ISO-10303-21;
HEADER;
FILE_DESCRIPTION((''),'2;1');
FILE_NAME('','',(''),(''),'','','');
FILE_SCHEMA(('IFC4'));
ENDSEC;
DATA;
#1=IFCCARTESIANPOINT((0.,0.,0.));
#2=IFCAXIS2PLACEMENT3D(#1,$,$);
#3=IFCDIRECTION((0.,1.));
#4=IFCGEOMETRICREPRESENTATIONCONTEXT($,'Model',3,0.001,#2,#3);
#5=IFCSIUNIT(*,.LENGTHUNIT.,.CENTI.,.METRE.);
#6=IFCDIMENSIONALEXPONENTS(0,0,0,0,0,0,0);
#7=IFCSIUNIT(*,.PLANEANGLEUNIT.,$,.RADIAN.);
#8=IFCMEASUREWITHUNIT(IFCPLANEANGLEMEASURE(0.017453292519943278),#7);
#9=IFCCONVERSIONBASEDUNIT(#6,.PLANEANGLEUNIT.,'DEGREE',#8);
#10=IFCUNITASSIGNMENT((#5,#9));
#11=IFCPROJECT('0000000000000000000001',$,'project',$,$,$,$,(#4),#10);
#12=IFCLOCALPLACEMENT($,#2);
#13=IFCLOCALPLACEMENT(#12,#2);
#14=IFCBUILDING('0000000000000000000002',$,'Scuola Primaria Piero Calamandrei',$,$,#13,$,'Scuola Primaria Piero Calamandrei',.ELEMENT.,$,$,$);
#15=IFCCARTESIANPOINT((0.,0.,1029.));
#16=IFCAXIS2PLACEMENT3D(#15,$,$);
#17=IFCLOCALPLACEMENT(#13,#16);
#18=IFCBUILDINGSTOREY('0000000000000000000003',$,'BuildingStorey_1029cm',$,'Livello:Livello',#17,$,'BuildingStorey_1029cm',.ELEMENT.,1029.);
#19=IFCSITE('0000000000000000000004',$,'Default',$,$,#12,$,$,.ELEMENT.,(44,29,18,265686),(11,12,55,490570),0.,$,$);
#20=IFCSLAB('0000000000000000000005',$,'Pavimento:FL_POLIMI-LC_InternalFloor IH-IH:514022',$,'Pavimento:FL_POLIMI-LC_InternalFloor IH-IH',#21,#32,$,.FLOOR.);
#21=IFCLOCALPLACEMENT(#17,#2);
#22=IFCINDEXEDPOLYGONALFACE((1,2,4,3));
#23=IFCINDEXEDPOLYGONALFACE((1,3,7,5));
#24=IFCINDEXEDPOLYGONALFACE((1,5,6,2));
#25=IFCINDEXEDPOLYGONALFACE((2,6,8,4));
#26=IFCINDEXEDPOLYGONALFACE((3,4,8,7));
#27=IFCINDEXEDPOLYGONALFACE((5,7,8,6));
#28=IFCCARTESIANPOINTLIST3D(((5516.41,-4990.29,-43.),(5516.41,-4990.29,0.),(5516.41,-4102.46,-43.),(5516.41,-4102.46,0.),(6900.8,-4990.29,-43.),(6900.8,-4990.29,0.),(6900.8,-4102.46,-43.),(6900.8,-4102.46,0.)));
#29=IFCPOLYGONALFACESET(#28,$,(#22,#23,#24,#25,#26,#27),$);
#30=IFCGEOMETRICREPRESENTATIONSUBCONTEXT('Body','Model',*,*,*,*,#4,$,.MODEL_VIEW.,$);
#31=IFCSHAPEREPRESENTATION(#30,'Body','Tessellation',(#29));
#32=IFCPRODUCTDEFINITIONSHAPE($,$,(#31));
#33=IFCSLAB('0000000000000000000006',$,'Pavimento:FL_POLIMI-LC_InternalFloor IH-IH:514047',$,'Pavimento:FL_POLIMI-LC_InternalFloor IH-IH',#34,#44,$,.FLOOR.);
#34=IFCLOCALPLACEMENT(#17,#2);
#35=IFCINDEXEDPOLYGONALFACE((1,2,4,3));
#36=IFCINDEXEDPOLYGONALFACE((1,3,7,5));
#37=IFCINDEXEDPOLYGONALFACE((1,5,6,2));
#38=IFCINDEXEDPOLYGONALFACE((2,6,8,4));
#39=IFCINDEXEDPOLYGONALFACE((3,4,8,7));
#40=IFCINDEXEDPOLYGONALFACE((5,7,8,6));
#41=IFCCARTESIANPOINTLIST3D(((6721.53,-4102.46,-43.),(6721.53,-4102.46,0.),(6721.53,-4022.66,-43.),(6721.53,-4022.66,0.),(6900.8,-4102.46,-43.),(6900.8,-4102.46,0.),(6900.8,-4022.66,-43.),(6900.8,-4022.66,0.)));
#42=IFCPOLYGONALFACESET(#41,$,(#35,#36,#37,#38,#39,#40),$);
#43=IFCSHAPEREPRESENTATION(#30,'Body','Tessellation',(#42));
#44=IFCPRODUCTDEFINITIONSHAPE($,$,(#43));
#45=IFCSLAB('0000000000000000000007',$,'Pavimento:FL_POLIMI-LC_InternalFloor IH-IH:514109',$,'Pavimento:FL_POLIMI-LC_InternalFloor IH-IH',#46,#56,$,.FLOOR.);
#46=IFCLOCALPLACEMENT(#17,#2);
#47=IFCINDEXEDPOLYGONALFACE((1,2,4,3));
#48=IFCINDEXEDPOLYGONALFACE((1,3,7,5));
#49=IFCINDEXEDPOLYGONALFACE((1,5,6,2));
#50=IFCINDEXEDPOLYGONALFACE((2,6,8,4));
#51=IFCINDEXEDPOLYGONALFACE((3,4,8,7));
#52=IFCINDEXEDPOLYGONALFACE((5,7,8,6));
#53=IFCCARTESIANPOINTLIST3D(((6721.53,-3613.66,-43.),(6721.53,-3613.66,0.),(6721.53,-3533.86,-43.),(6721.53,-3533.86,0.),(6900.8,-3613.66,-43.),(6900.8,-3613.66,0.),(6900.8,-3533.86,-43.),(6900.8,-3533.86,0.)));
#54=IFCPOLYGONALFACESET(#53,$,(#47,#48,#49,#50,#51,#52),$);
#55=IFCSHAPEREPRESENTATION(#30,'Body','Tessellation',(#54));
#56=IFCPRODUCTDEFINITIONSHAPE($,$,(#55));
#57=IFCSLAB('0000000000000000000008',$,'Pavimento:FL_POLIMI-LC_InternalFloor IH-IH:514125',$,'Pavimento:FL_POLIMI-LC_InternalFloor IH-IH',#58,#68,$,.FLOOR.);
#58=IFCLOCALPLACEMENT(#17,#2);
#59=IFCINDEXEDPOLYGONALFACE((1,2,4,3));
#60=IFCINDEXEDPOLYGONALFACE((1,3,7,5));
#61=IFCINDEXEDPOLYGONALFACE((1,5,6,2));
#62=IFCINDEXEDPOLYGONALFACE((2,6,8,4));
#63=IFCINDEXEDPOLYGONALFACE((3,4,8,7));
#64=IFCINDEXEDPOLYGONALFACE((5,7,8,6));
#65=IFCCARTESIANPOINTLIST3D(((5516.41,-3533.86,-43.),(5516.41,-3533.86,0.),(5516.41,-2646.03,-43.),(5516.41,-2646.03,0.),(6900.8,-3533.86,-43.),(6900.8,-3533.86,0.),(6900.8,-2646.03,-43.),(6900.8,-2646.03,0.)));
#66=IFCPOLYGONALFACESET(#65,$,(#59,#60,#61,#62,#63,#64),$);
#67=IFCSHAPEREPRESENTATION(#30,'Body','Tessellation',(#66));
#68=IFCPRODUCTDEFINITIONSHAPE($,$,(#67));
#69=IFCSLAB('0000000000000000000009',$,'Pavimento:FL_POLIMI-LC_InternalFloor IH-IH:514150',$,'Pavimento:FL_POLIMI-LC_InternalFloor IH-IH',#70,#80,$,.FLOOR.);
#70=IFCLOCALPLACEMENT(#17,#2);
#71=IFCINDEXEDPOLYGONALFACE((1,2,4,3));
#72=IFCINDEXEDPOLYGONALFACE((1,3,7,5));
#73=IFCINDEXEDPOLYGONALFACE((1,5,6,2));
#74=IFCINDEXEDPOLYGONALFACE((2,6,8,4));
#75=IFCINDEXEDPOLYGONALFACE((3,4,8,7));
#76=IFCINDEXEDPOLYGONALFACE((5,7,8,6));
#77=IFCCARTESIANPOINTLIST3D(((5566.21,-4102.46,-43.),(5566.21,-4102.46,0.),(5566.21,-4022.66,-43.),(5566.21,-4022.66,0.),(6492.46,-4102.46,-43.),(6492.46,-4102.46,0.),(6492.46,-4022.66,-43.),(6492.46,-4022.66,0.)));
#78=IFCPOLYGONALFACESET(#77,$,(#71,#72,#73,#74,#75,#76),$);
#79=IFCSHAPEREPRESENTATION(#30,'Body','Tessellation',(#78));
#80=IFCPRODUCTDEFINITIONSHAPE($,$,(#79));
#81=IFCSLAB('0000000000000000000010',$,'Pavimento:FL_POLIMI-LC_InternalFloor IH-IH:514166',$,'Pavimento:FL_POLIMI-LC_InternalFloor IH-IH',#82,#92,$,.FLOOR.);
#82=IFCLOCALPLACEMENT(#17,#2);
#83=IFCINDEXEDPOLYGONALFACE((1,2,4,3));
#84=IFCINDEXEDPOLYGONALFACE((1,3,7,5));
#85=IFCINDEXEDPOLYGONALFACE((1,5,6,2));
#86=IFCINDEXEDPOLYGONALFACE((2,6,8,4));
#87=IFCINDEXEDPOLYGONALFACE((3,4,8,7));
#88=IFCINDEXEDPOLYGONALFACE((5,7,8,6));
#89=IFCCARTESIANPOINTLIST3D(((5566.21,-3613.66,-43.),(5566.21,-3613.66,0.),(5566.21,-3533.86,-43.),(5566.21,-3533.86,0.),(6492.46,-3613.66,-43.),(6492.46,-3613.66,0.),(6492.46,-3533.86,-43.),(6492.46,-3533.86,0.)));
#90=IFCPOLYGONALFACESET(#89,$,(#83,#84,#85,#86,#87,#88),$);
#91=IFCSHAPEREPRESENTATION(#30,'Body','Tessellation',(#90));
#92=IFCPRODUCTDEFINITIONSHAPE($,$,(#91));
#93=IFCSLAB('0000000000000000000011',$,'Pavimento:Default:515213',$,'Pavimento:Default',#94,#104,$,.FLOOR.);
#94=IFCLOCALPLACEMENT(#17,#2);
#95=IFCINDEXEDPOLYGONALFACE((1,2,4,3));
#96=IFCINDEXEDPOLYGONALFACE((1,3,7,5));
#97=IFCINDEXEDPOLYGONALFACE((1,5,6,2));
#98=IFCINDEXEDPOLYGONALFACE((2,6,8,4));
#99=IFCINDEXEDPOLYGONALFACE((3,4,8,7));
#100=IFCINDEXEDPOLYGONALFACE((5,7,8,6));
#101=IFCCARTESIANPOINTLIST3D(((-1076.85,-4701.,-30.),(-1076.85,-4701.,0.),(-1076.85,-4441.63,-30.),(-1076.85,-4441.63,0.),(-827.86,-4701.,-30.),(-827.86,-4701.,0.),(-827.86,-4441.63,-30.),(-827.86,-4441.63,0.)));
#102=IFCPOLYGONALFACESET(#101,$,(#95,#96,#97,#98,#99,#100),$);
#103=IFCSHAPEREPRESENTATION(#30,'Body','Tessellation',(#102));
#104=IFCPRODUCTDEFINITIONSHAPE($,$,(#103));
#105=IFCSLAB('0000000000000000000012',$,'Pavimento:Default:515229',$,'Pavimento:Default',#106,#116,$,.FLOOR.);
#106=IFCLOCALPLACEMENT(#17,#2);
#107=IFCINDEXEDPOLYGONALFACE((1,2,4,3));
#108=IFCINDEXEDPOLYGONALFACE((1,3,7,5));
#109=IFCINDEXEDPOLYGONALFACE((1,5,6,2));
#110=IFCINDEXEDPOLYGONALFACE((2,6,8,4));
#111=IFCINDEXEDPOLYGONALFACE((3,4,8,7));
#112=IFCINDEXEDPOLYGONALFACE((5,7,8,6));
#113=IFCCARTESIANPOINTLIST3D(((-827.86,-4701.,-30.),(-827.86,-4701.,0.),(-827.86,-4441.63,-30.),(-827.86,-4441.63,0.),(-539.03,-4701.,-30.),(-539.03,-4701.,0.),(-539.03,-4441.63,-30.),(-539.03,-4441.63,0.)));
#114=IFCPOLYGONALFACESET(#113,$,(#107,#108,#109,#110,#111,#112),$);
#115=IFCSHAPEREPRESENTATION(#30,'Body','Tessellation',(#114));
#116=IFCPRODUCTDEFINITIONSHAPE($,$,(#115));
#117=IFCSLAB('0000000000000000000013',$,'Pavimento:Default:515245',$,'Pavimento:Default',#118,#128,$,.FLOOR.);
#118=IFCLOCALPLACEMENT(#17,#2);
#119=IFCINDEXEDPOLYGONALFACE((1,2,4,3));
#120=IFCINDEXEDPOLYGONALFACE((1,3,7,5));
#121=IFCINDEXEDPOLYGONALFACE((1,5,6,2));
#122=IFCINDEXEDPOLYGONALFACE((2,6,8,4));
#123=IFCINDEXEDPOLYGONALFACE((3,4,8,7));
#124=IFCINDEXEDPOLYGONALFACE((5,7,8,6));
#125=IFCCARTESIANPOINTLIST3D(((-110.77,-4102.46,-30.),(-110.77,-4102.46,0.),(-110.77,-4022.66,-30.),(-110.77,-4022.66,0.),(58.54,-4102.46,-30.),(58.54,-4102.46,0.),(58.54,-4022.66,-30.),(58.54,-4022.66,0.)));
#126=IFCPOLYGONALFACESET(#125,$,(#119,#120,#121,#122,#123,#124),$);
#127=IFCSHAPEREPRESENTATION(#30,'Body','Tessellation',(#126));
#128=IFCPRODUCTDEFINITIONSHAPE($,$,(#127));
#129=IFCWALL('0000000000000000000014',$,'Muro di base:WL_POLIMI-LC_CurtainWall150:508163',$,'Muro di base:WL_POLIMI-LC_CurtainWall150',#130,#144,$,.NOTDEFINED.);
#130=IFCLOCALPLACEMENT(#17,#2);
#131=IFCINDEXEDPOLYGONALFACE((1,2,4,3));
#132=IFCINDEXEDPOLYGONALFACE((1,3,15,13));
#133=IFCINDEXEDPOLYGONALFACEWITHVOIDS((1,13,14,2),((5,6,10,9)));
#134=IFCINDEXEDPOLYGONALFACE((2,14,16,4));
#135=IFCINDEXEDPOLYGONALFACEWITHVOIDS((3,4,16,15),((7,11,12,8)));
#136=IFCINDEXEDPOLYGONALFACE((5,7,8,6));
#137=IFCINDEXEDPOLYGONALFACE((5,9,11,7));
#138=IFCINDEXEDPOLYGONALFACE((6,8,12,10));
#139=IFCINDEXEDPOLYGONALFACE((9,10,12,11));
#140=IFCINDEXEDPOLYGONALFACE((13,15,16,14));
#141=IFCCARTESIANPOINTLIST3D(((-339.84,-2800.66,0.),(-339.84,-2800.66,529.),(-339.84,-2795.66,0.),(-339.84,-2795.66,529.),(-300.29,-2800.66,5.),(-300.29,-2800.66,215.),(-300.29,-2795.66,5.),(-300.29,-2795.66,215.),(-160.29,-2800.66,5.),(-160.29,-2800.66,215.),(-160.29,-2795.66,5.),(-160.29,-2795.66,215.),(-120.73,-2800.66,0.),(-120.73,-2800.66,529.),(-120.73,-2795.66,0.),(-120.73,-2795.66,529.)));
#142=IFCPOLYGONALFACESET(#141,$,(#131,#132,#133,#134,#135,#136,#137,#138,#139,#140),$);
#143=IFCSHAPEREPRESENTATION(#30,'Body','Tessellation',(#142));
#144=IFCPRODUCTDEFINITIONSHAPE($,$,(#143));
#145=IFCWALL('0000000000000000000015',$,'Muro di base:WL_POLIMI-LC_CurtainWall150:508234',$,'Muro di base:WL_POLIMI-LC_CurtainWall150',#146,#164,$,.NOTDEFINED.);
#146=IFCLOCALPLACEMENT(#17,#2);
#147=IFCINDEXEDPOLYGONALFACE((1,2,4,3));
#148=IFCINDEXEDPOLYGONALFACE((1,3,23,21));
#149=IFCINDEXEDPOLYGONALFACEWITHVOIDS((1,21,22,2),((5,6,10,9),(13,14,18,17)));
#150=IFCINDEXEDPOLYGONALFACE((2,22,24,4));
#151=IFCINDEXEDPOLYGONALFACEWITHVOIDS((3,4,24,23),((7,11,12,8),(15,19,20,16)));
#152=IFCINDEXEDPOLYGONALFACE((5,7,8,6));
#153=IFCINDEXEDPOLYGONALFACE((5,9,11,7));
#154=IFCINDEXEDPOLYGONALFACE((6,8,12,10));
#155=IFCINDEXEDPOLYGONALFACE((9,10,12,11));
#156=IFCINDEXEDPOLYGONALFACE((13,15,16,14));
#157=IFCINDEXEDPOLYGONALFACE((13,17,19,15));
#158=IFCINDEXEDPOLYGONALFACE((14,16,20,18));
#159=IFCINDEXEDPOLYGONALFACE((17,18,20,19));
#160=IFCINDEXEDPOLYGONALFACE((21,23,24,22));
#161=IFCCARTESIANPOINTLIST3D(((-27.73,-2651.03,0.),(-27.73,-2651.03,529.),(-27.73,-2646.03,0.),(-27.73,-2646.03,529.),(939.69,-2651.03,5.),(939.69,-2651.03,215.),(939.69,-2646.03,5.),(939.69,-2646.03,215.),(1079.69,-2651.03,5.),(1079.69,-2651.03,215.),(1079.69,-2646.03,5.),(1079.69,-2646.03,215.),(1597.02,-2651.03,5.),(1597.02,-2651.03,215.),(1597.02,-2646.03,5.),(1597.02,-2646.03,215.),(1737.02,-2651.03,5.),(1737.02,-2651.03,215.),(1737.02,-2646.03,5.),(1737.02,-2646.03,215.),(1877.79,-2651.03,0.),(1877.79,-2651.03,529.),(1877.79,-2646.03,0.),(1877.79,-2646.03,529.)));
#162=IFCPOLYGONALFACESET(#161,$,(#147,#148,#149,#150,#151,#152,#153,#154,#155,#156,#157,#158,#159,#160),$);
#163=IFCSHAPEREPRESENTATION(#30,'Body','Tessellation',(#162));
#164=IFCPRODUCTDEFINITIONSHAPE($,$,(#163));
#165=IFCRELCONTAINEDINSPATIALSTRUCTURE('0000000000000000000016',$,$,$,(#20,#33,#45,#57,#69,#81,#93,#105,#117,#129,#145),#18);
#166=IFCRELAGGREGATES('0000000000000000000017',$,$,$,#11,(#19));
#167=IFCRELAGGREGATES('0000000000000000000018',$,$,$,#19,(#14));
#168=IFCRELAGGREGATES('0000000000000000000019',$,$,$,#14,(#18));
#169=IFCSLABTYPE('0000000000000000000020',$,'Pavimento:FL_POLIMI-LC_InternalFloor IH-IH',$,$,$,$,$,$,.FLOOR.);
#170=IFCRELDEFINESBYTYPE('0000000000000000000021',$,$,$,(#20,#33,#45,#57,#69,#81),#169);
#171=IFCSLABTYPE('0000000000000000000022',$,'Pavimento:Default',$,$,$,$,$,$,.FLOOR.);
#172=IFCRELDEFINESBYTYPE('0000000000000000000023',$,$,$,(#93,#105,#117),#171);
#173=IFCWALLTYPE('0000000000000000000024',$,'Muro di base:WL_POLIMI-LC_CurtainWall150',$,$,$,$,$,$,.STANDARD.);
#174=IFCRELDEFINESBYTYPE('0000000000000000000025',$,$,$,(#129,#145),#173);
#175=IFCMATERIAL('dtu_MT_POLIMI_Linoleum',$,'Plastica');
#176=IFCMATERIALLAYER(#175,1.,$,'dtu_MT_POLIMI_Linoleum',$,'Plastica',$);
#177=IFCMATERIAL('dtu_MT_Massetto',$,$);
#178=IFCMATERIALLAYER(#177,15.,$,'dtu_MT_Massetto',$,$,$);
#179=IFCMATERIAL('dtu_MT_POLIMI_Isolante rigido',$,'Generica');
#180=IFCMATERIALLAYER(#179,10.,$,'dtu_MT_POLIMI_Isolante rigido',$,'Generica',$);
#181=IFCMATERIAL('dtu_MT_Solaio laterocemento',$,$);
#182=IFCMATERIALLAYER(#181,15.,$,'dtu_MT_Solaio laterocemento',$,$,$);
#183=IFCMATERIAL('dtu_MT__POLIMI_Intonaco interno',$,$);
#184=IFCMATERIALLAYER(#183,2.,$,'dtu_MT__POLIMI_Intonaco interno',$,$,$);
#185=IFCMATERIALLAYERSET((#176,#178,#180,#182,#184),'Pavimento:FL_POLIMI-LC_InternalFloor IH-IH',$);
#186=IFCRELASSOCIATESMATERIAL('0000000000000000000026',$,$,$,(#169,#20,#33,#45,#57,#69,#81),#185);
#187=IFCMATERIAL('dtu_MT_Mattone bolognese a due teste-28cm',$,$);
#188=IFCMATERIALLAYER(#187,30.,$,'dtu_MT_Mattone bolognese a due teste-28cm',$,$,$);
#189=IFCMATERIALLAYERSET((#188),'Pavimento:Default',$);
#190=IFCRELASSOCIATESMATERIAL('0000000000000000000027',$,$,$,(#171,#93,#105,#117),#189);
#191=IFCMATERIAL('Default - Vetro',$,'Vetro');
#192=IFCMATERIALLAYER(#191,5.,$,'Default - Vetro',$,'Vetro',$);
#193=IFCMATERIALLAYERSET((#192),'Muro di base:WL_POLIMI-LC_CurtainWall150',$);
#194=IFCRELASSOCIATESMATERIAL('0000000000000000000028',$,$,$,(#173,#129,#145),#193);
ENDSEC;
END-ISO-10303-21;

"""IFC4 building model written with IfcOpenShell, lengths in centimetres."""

from ifc_helpers import new_model, entity, si_unit, converted_unit, direction, frame, frame_2d, origin, place, context, subcontext, project, spatial, rectangle, extrude, material, layer, layer_set, layer_usage, type_object, element, save


model = new_model("IFC4")

# Units and contexts
model_context = context("Model", 3, precision=0.001, world=origin(), true_north=direction((0.0, 1.0)))
body_context = subcontext(model_context, "Body", "Model", "MODEL_VIEW")
ifc_project = project(units=[si_unit("LENGTHUNIT", "METRE", prefix="CENTI"), converted_unit("PLANEANGLEUNIT", "DEGREE", entity("IfcPlaneAngleMeasure", 0.017453292519943278), si_unit("PLANEANGLEUNIT", "RADIAN"), dimensions=[0, 0, 0, 0, 0, 0, 0])], contexts=[model_context])

# Site, building, storey
site_placement = place(None, origin())
site = spatial("IfcSite", under=ifc_project, at=site_placement, Name="Default", CompositionType="ELEMENT", RefLatitude=(44, 29, 18, 265686), RefLongitude=(11, 12, 55, 490570), RefElevation=0.0)
building_placement = place(site_placement, origin())
building = spatial("IfcBuilding", under=site, at=building_placement, Name="Scuola Primaria Piero Calamandrei", LongName="Scuola Primaria Piero Calamandrei", CompositionType="ELEMENT")
storey_placement = place(building_placement, frame((0.0, 0.0, 1029.0)))
storey = spatial("IfcBuildingStorey", under=building, at=storey_placement, Name="BuildingStorey_1029cm", ObjectType="Livello:Livello", LongName="BuildingStorey_1029cm", CompositionType="ELEMENT", Elevation=1029.0)

# Slabs
ifc_material_1 = material(Name="dtu_MT_POLIMI_Linoleum", Category="Plastica")
ifc_layer_1 = layer(ifc_material_1, 1.0, Name="dtu_MT_POLIMI_Linoleum", Category="Plastica")
ifc_material_2 = material(Name="dtu_MT_Massetto")
ifc_layer_2 = layer(ifc_material_2, 15.0, Name="dtu_MT_Massetto")
ifc_material_3 = material(Name="dtu_MT_POLIMI_Isolante rigido", Category="Generica")
ifc_layer_3 = layer(ifc_material_3, 10.0, Name="dtu_MT_POLIMI_Isolante rigido", Category="Generica")
ifc_material_4 = material(Name="dtu_MT_Solaio laterocemento")
ifc_layer_4 = layer(ifc_material_4, 15.0, Name="dtu_MT_Solaio laterocemento")
ifc_material_5 = material(Name="dtu_MT__POLIMI_Intonaco interno")
ifc_layer_5 = layer(ifc_material_5, 2.0, Name="dtu_MT__POLIMI_Intonaco interno")
ifc_layer_set_1 = layer_set([ifc_layer_1, ifc_layer_2, ifc_layer_3, ifc_layer_4, ifc_layer_5], Name="Pavimento:FL_POLIMI-LC_InternalFloor IH-IH")
slab_type_1 = type_object("IfcSlabType", Name="Pavimento:FL_POLIMI-LC_InternalFloor IH-IH", PredefinedType="FLOOR", material=ifc_layer_set_1)
ifc_layer_usage_1 = layer_usage(ifc_layer_set_1, "AXIS3", "POSITIVE", 0.0)
slab_1_placement = place(storey_placement, origin())
element("IfcSlab", 1, at=slab_1_placement, inside=storey, type_object=slab_type_1, material=ifc_layer_usage_1, Name="Pavimento:FL_POLIMI-LC_InternalFloor IH-IH:514022", ObjectType="Pavimento:FL_POLIMI-LC_InternalFloor IH-IH", PredefinedType="FLOOR", context=body_context, shape_type="SweptSolid", body=[
    extrude(rectangle(XDim=887.82, YDim=1384.39, at=frame_2d((0.0, 0.0), x_axis=(1.0, 0.0))), frame((6208.61, -4546.38, 0.0), z_axis=(0.0, 0.0, -1.0), x_axis=(0.0, 1.0, 0.0)), (0.0, 0.0, 1.0), 43.0),
])
ifc_layer_usage_2 = layer_usage(ifc_layer_set_1, "AXIS3", "POSITIVE", 0.0)
slab_2_placement = place(storey_placement, origin())
element("IfcSlab", 2, at=slab_2_placement, inside=storey, type_object=slab_type_1, material=ifc_layer_usage_2, Name="Pavimento:FL_POLIMI-LC_InternalFloor IH-IH:514047", ObjectType="Pavimento:FL_POLIMI-LC_InternalFloor IH-IH", PredefinedType="FLOOR", context=body_context, shape_type="SweptSolid", body=[
    extrude(rectangle(XDim=79.8, YDim=179.27, at=frame_2d((0.0, 0.0), x_axis=(1.0, 0.0))), frame((6811.16, -4062.56, 0.0), z_axis=(0.0, 0.0, -1.0), x_axis=(0.0, 1.0, 0.0)), (0.0, 0.0, 1.0), 43.0),
])
ifc_layer_usage_3 = layer_usage(ifc_layer_set_1, "AXIS3", "POSITIVE", 0.0)
slab_3_placement = place(storey_placement, origin())
element("IfcSlab", 3, at=slab_3_placement, inside=storey, type_object=slab_type_1, material=ifc_layer_usage_3, Name="Pavimento:FL_POLIMI-LC_InternalFloor IH-IH:514109", ObjectType="Pavimento:FL_POLIMI-LC_InternalFloor IH-IH", PredefinedType="FLOOR", context=body_context, shape_type="SweptSolid", body=[
    extrude(rectangle(XDim=79.8, YDim=179.27, at=frame_2d((0.0, 0.0), x_axis=(1.0, 0.0))), frame((6811.16, -3573.76, 0.0), z_axis=(0.0, 0.0, -1.0), x_axis=(0.0, 1.0, 0.0)), (0.0, 0.0, 1.0), 43.0),
])
ifc_layer_usage_4 = layer_usage(ifc_layer_set_1, "AXIS3", "POSITIVE", 0.0)
slab_4_placement = place(storey_placement, origin())
element("IfcSlab", 4, at=slab_4_placement, inside=storey, type_object=slab_type_1, material=ifc_layer_usage_4, Name="Pavimento:FL_POLIMI-LC_InternalFloor IH-IH:514125", ObjectType="Pavimento:FL_POLIMI-LC_InternalFloor IH-IH", PredefinedType="FLOOR", context=body_context, shape_type="SweptSolid", body=[
    extrude(rectangle(XDim=887.82, YDim=1384.39, at=frame_2d((0.0, 0.0), x_axis=(1.0, 0.0))), frame((6208.61, -3089.94, 0.0), z_axis=(0.0, 0.0, -1.0), x_axis=(0.0, 1.0, 0.0)), (0.0, 0.0, 1.0), 43.0),
])
ifc_layer_usage_5 = layer_usage(ifc_layer_set_1, "AXIS3", "POSITIVE", 0.0)
slab_5_placement = place(storey_placement, origin())
element("IfcSlab", 5, at=slab_5_placement, inside=storey, type_object=slab_type_1, material=ifc_layer_usage_5, Name="Pavimento:FL_POLIMI-LC_InternalFloor IH-IH:514150", ObjectType="Pavimento:FL_POLIMI-LC_InternalFloor IH-IH", PredefinedType="FLOOR", context=body_context, shape_type="SweptSolid", body=[
    extrude(rectangle(XDim=79.8, YDim=926.24, at=frame_2d((0.0, 0.0), x_axis=(1.0, 0.0))), frame((6029.33, -4062.56, 0.0), z_axis=(0.0, 0.0, -1.0), x_axis=(0.0, 1.0, 0.0)), (0.0, 0.0, 1.0), 43.0),
])
ifc_layer_usage_6 = layer_usage(ifc_layer_set_1, "AXIS3", "POSITIVE", 0.0)
slab_6_placement = place(storey_placement, origin())
element("IfcSlab", 6, at=slab_6_placement, inside=storey, type_object=slab_type_1, material=ifc_layer_usage_6, Name="Pavimento:FL_POLIMI-LC_InternalFloor IH-IH:514166", ObjectType="Pavimento:FL_POLIMI-LC_InternalFloor IH-IH", PredefinedType="FLOOR", context=body_context, shape_type="SweptSolid", body=[
    extrude(rectangle(XDim=79.8, YDim=926.24, at=frame_2d((0.0, 0.0), x_axis=(1.0, 0.0))), frame((6029.33, -3573.76, 0.0), z_axis=(0.0, 0.0, -1.0), x_axis=(0.0, 1.0, 0.0)), (0.0, 0.0, 1.0), 43.0),
])
ifc_material_6 = material(Name="dtu_MT_Mattone bolognese a due teste-28cm")
ifc_layer_6 = layer(ifc_material_6, 30.0, Name="dtu_MT_Mattone bolognese a due teste-28cm")
ifc_layer_set_2 = layer_set([ifc_layer_6], Name="Pavimento:Default")
slab_type_2 = type_object("IfcSlabType", Name="Pavimento:Default", PredefinedType="FLOOR", material=ifc_layer_set_2)
ifc_layer_usage_7 = layer_usage(ifc_layer_set_2, "AXIS3", "POSITIVE", 0.0)
slab_7_placement = place(storey_placement, origin())
element("IfcSlab", 7, at=slab_7_placement, inside=storey, type_object=slab_type_2, material=ifc_layer_usage_7, Name="Pavimento:Default:515213", ObjectType="Pavimento:Default", PredefinedType="FLOOR", context=body_context, shape_type="SweptSolid", body=[
    extrude(rectangle(XDim=259.36, YDim=248.99, at=frame_2d((0.0, 0.0), x_axis=(1.0, 0.0))), frame((-952.36, -4571.31, 0.0), z_axis=(0.0, 0.0, -1.0), x_axis=(0.0, 1.0, 0.0)), (0.0, 0.0, 1.0), 30.0),
])
ifc_layer_usage_8 = layer_usage(ifc_layer_set_2, "AXIS3", "POSITIVE", 0.0)
slab_8_placement = place(storey_placement, origin())
element("IfcSlab", 8, at=slab_8_placement, inside=storey, type_object=slab_type_2, material=ifc_layer_usage_8, Name="Pavimento:Default:515229", ObjectType="Pavimento:Default", PredefinedType="FLOOR", context=body_context, shape_type="SweptSolid", body=[
    extrude(rectangle(XDim=259.36, YDim=288.83, at=frame_2d((0.0, 0.0), x_axis=(1.0, 0.0))), frame((-683.45, -4571.31, 0.0), z_axis=(0.0, 0.0, -1.0), x_axis=(0.0, 1.0, 0.0)), (0.0, 0.0, 1.0), 30.0),
])
ifc_layer_usage_9 = layer_usage(ifc_layer_set_2, "AXIS3", "POSITIVE", 0.0)
slab_9_placement = place(storey_placement, origin())
element("IfcSlab", 9, at=slab_9_placement, inside=storey, type_object=slab_type_2, material=ifc_layer_usage_9, Name="Pavimento:Default:515245", ObjectType="Pavimento:Default", PredefinedType="FLOOR", context=body_context, shape_type="SweptSolid", body=[
    extrude(rectangle(XDim=79.8, YDim=169.31, at=frame_2d((0.0, 0.0), x_axis=(1.0, 0.0))), frame((-26.11, -4062.56, 0.0), z_axis=(0.0, 0.0, -1.0), x_axis=(0.0, 1.0, 0.0)), (0.0, 0.0, 1.0), 30.0),
])

# Wall, opening
ifc_material_7 = material(Name="Default - Vetro", Category="Vetro")
ifc_layer_7 = layer(ifc_material_7, 5.0, Name="Default - Vetro", Category="Vetro")
ifc_layer_set_3 = layer_set([ifc_layer_7], Name="Muro di base:WL_POLIMI-LC_CurtainWall150")
ifc_layer_usage_10 = layer_usage(ifc_layer_set_3, "AXIS2", "NEGATIVE", 2.5)
wall_type_1 = type_object("IfcWallType", Name="Muro di base:WL_POLIMI-LC_CurtainWall150", PredefinedType="STANDARD", material=ifc_layer_set_3)
wall_1_placement = place(storey_placement, frame((-339.84, -2798.16, 0.0)))
wall_1 = element("IfcWall", 10, at=wall_1_placement, inside=storey, type_object=wall_type_1, material=ifc_layer_usage_10, Name="Muro di base:WL_POLIMI-LC_CurtainWall150:508163", ObjectType="Muro di base:WL_POLIMI-LC_CurtainWall150", PredefinedType="NOTDEFINED", context=body_context, shape_type="SweptSolid", body=[
    extrude(rectangle(XDim=219.11, YDim=5.0, at=frame_2d((109.56, 0.0), x_axis=(-1.0, 0.0))), origin(), (0.0, 0.0, 1.0), 529.0),
])
opening_1_placement = place(wall_1_placement, frame((179.56, 2.5, 5.0)))
element("IfcOpeningElement", 11, at=opening_1_placement, cuts=wall_1, PredefinedType="OPENING", context=body_context, shape_type="SweptSolid", body=[
    extrude(rectangle(XDim=210.0, YDim=140.0, at=frame_2d((105.0, 70.0), x_axis=(1.0, 0.0))), frame((0.0, 0.0, 0.0), z_axis=(0.0, -1.0, 0.0), x_axis=(0.0, 0.0, 1.0)), (0.0, 0.0, 1.0), 5.0),
])

# Wall, openings
ifc_layer_usage_11 = layer_usage(ifc_layer_set_3, "AXIS2", "NEGATIVE", 2.5)
wall_2_placement = place(storey_placement, frame((-27.73, -2648.53, 0.0)))
wall_2 = element("IfcWall", 12, at=wall_2_placement, inside=storey, type_object=wall_type_1, material=ifc_layer_usage_11, Name="Muro di base:WL_POLIMI-LC_CurtainWall150:508234", ObjectType="Muro di base:WL_POLIMI-LC_CurtainWall150", PredefinedType="NOTDEFINED", context=body_context, shape_type="SweptSolid", body=[
    extrude(rectangle(XDim=1905.52, YDim=5.0, at=frame_2d((952.76, 0.0), x_axis=(-1.0, 0.0))), origin(), (0.0, 0.0, 1.0), 529.0),
])
opening_2_placement = place(wall_2_placement, frame((1624.75, -2.5, 5.0)))
element("IfcOpeningElement", 13, at=opening_2_placement, cuts=wall_2, PredefinedType="OPENING", context=body_context, shape_type="SweptSolid", body=[
    extrude(rectangle(XDim=210.0, YDim=140.0, at=frame_2d((105.0, 70.0), x_axis=(-1.0, 0.0))), frame((0.0, 0.0, 0.0), z_axis=(0.0, 1.0, 0.0), x_axis=(0.0, 0.0, 1.0)), (0.0, 0.0, 1.0), 5.0),
])
opening_3_placement = place(wall_2_placement, frame((967.42, -2.5, 5.0)))
element("IfcOpeningElement", 14, at=opening_3_placement, cuts=wall_2, PredefinedType="OPENING", context=body_context, shape_type="SweptSolid", body=[
    extrude(rectangle(XDim=210.0, YDim=140.0, at=frame_2d((105.0, 70.0), x_axis=(-1.0, 0.0))), frame((0.0, 0.0, 0.0), z_axis=(0.0, 1.0, 0.0), x_axis=(0.0, 0.0, 1.0)), (0.0, 0.0, 1.0), 5.0),
])

save(model, "model.ifc")
